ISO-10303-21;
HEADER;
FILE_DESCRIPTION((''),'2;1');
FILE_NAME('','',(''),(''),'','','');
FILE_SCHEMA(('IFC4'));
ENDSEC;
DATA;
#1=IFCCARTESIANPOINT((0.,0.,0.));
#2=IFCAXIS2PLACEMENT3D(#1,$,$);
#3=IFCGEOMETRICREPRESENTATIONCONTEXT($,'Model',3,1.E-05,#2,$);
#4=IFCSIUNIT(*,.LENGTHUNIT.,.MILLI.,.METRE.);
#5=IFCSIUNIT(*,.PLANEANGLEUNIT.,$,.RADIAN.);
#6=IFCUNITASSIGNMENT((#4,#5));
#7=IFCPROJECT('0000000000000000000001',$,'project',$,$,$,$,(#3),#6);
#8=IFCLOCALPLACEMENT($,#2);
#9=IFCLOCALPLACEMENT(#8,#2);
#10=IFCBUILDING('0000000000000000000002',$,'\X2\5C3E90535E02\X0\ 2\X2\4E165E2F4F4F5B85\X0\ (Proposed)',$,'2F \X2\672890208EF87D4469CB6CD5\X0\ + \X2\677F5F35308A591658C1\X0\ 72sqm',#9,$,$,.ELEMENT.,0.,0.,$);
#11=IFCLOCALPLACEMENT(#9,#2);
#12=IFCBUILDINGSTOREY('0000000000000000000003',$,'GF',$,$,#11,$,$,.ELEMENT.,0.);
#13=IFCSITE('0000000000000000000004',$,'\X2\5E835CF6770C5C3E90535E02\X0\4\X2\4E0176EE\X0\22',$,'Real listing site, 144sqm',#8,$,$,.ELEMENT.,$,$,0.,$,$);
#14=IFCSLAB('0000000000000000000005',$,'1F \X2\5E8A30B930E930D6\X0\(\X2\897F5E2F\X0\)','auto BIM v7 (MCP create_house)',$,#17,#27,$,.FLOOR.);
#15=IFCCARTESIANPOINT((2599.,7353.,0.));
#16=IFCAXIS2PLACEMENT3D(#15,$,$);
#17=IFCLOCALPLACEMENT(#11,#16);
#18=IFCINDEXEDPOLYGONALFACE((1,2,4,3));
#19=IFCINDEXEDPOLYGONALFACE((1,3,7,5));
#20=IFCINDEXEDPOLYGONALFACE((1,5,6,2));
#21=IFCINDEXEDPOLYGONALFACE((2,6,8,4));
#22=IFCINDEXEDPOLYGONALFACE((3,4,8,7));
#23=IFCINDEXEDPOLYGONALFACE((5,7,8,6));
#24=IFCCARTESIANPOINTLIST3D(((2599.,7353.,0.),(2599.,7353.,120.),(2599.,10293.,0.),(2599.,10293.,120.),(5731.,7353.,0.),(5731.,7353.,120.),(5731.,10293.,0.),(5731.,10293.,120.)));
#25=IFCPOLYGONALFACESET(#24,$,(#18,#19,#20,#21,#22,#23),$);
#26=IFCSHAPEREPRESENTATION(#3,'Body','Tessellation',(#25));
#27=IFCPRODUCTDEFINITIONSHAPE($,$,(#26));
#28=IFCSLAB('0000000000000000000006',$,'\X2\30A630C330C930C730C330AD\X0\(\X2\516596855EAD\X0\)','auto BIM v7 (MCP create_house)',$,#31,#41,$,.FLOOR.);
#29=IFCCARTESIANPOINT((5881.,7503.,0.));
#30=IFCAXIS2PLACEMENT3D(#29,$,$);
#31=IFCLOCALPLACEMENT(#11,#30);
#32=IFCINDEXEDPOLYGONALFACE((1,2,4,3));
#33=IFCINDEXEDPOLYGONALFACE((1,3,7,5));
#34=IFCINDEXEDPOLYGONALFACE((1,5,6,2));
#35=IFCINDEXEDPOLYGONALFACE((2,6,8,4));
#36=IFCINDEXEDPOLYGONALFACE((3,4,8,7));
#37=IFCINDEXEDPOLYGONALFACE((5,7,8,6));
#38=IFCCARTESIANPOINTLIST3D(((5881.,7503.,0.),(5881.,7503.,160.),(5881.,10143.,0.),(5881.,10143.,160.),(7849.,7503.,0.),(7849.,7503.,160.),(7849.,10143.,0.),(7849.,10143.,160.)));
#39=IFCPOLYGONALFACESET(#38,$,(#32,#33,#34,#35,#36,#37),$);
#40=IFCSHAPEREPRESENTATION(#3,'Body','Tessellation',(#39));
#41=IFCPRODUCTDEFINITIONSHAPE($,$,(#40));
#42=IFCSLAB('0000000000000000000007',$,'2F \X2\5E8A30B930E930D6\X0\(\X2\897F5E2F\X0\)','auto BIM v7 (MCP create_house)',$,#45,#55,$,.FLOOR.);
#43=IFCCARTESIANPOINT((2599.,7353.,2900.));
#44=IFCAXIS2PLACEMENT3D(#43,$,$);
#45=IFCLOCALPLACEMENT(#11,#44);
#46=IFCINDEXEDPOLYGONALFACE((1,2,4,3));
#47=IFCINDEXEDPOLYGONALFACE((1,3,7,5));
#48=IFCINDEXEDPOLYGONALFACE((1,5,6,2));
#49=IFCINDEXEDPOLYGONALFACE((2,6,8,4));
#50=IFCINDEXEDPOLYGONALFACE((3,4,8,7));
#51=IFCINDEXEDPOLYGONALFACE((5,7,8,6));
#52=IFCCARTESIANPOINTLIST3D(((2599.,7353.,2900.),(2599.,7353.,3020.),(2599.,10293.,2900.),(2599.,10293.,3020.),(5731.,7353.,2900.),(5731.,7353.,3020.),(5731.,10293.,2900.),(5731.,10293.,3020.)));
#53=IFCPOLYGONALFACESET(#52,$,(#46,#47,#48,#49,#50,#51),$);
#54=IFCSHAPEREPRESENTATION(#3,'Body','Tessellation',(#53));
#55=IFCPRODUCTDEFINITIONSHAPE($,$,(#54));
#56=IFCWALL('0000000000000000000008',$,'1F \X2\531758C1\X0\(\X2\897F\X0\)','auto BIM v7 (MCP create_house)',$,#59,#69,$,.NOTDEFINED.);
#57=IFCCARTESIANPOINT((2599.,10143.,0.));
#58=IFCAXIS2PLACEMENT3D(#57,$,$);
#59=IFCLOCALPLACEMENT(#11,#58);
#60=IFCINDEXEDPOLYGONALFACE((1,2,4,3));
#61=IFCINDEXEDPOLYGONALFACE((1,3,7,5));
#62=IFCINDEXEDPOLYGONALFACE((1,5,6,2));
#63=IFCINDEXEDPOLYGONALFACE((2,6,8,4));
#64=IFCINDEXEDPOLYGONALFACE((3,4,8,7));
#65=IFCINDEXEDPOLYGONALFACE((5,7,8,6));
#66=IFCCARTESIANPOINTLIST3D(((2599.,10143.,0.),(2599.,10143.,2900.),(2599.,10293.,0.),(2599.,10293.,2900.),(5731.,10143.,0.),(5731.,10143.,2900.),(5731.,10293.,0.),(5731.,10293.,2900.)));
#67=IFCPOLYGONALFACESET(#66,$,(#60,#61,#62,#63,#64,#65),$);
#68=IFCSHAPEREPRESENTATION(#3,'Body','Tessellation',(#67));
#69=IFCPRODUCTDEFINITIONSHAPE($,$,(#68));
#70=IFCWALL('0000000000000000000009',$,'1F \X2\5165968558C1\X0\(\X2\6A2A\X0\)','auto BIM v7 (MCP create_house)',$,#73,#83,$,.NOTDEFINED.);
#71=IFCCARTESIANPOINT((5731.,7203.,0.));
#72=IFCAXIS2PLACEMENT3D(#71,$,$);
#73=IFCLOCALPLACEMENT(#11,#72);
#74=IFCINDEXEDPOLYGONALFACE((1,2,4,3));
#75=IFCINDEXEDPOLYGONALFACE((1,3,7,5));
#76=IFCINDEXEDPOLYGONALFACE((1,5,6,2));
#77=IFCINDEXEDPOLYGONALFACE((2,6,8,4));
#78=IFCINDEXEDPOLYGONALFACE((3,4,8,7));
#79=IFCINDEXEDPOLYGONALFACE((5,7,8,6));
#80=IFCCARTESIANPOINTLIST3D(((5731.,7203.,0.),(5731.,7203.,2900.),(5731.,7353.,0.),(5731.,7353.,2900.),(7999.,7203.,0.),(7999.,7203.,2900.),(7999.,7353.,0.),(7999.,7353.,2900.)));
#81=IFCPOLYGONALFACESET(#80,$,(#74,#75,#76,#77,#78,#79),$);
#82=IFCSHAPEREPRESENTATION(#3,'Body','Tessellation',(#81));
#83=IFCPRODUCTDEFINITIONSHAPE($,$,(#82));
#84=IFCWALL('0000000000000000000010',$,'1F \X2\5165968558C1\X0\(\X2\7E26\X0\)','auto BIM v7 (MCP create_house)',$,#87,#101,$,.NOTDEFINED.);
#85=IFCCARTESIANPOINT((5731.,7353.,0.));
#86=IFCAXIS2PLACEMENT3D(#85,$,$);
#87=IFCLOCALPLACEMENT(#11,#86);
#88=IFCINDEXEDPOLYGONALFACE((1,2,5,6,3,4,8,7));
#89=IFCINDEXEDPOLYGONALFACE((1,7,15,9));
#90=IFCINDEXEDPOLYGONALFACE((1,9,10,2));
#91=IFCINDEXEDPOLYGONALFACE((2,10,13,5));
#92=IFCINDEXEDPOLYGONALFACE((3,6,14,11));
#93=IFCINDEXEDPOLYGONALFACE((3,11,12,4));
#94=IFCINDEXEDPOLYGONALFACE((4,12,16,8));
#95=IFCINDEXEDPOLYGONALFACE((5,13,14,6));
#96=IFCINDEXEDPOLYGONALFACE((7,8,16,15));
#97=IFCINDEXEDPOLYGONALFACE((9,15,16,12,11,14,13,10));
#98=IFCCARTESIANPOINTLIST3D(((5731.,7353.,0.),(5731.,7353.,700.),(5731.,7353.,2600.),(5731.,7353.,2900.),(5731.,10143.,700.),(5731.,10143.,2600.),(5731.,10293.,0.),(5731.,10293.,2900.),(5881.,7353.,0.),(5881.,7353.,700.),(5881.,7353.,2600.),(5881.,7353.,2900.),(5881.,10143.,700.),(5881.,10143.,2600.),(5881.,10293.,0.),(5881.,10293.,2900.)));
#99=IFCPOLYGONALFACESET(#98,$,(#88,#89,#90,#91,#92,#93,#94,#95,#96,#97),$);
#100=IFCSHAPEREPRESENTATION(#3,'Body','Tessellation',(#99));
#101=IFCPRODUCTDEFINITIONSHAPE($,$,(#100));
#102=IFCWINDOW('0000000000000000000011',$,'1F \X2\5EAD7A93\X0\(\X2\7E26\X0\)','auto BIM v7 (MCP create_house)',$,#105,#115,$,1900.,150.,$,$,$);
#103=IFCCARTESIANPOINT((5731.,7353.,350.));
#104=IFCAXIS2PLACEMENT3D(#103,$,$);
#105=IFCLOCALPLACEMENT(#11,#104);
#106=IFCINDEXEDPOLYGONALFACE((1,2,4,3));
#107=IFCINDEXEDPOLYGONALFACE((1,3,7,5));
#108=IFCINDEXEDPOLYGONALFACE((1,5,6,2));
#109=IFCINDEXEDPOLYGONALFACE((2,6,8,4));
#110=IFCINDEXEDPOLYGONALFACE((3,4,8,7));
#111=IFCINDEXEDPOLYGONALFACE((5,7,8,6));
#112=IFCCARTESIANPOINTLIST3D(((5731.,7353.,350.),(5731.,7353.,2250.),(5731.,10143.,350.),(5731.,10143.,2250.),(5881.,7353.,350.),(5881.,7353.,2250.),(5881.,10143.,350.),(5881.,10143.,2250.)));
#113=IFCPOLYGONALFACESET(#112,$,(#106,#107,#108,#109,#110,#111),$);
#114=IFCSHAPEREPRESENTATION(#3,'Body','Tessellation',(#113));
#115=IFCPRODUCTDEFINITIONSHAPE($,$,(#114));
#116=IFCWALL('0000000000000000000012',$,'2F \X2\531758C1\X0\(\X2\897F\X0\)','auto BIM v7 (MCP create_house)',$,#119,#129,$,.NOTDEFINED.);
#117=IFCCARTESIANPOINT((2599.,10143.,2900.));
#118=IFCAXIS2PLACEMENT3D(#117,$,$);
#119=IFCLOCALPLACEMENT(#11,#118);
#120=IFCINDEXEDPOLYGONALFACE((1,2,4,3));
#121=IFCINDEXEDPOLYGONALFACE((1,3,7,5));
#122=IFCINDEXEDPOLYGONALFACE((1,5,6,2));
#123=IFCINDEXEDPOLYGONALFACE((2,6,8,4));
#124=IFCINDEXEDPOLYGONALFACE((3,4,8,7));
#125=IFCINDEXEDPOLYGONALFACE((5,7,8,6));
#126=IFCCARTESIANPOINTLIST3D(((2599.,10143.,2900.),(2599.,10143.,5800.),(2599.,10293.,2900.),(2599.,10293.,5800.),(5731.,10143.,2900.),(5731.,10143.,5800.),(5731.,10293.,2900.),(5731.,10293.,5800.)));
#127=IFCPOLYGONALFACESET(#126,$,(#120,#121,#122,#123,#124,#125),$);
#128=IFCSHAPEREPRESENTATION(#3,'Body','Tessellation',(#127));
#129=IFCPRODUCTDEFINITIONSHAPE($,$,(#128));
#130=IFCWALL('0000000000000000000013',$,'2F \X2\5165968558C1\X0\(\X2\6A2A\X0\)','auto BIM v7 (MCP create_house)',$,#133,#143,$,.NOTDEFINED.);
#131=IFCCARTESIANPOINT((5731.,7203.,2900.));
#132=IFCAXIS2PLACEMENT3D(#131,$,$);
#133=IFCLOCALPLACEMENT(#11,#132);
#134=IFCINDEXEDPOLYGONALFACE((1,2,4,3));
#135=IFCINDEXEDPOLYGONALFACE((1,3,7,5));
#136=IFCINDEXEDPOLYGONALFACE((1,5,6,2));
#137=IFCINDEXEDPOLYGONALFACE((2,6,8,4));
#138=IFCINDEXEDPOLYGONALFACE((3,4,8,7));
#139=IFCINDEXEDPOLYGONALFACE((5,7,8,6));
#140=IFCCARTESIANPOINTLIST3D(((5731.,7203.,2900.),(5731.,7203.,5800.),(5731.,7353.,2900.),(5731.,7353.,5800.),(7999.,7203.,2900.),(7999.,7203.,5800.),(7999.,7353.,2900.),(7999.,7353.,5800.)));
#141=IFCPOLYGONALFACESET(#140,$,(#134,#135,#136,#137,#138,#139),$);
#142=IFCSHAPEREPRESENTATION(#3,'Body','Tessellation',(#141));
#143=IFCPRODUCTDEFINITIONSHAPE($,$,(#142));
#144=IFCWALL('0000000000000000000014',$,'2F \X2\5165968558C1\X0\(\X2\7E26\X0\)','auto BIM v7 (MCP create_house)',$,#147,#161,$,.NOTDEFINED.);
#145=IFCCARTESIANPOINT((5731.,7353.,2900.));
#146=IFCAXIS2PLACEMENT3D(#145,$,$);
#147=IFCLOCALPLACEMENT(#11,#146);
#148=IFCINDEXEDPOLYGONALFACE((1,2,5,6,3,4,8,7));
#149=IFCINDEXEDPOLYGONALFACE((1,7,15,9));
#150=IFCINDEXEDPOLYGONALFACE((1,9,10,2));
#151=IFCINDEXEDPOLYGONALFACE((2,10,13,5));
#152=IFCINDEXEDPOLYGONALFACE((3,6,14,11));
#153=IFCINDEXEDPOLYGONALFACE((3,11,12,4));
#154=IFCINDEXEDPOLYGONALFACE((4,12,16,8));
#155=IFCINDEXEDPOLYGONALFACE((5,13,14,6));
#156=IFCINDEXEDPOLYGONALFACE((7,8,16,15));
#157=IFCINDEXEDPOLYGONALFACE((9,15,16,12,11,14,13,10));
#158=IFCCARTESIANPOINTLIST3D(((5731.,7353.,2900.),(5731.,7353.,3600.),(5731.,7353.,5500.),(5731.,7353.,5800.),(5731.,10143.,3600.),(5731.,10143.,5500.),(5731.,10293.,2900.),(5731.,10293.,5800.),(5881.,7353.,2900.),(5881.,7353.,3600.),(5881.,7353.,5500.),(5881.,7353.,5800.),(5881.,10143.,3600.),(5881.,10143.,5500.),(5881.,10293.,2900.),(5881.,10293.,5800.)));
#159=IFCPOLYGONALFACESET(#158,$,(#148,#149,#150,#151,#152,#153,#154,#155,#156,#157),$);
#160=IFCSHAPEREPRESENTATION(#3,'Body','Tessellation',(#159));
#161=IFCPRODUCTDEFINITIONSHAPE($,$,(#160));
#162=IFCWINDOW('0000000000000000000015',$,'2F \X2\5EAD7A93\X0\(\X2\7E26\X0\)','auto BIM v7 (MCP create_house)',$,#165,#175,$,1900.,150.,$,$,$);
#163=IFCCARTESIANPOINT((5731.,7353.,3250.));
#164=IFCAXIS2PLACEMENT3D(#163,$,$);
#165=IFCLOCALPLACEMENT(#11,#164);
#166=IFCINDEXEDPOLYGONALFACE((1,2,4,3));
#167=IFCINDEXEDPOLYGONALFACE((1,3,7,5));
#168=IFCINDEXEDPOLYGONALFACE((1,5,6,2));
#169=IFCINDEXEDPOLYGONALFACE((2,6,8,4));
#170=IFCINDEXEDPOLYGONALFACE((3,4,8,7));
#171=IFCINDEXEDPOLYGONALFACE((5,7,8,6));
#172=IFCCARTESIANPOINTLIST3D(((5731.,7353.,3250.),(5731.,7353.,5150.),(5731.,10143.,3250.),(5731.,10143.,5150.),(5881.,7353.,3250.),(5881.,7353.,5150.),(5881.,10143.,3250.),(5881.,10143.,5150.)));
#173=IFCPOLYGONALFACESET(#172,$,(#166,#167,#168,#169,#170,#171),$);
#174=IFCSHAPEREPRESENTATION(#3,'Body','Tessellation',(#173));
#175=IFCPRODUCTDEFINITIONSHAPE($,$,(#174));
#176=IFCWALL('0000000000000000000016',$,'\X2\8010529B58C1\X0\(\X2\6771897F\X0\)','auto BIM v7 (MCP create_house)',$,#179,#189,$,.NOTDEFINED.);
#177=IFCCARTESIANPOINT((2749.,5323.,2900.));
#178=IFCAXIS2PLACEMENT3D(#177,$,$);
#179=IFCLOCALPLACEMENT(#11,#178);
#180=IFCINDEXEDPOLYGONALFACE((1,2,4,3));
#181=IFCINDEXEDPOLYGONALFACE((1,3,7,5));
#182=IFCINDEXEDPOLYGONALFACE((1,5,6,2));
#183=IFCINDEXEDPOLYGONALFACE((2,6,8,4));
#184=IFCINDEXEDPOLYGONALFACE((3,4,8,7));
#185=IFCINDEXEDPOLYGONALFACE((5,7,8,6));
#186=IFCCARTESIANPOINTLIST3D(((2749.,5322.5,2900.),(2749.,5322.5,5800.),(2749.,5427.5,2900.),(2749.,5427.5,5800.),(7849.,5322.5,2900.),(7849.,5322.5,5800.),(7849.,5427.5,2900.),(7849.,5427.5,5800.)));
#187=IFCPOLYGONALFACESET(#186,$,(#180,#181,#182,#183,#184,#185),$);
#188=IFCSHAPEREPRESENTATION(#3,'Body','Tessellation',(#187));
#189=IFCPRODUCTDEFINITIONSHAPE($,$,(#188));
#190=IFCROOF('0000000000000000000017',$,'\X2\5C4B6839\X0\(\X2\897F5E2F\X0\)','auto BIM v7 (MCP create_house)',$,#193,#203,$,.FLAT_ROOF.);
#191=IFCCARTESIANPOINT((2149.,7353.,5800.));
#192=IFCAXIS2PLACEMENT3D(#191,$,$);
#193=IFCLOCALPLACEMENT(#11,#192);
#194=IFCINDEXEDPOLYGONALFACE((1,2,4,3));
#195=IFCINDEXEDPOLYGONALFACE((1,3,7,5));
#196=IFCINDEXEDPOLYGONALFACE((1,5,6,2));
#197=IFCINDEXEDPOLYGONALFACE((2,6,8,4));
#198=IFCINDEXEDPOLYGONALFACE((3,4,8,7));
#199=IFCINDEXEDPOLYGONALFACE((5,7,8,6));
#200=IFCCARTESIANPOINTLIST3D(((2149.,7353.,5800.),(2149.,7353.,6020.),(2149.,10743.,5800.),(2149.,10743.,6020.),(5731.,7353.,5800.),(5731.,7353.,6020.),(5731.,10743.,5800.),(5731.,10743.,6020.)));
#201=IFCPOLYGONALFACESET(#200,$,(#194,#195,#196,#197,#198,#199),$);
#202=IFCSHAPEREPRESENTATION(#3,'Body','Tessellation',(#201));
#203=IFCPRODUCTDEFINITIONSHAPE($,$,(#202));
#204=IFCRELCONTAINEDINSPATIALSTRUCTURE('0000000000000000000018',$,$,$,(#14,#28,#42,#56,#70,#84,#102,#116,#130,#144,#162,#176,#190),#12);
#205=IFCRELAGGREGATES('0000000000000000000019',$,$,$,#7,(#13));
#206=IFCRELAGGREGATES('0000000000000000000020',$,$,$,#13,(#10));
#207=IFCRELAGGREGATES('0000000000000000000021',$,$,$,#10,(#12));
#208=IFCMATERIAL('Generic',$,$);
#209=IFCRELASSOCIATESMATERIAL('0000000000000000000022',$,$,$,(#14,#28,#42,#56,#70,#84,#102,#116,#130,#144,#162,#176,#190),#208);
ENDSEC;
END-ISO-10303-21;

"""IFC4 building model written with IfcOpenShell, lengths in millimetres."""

from ifc_helpers import new_model, si_unit, frame, frame_2d, origin, place, context, project, spatial, rectangle, extrude, material, element, fill, save


model = new_model("IFC4")

# Units and contexts
model_context = context("Model", 3, precision=1e-05, world=origin())
ifc_project = project(units=[si_unit("LENGTHUNIT", "METRE", prefix="MILLI"), si_unit("PLANEANGLEUNIT", "RADIAN")], contexts=[model_context])

# Site, building, storey
site_placement = place(None, origin())
site = spatial("IfcSite", under=ifc_project, at=site_placement, Name="広島県尾道市4丁目22", ObjectType="Real listing site, 144sqm", CompositionType="ELEMENT", RefElevation=0.0)
building_placement = place(site_placement, origin())
building = spatial("IfcBuilding", under=site, at=building_placement, Name="尾道市 2世帯住宅 (Proposed)", ObjectType="2F 木造軸組構法 + 板張り外壁 72sqm", CompositionType="ELEMENT", ElevationOfRefHeight=0.0, ElevationOfTerrain=0.0)
storey_placement = place(building_placement, origin())
storey = spatial("IfcBuildingStorey", under=building, at=storey_placement, Name="GF", CompositionType="ELEMENT", Elevation=0.0)

# Slabs
ifc_material = material(Name="Generic")
slab_1_placement = place(storey_placement, frame((2599.0, 7353.0, 0.0)))
element("IfcSlab", 1, at=slab_1_placement, inside=storey, material=ifc_material, Name="1F 床スラブ(西帯)", Description="auto BIM v7 (MCP create_house)", PredefinedType="FLOOR", context=model_context, shape_type="SweptSolid", body=[
    extrude(rectangle(XDim=3132.0, YDim=2940.0, at=frame_2d((1566.0, 1470.0))), frame((2599.0, 7353.0, 0.0)), (0.0, 0.0, 1.0), 120.0),
])
slab_2_placement = place(storey_placement, frame((5881.0, 7503.0, 0.0)))
element("IfcSlab", 2, at=slab_2_placement, inside=storey, material=ifc_material, Name="ウッドデッキ(入隅庭)", Description="auto BIM v7 (MCP create_house)", PredefinedType="FLOOR", context=model_context, shape_type="SweptSolid", body=[
    extrude(rectangle(XDim=1968.0, YDim=2640.0, at=frame_2d((984.0, 1320.0))), frame((5881.0, 7503.0, 0.0)), (0.0, 0.0, 1.0), 160.0),
])
slab_3_placement = place(storey_placement, frame((2599.0, 7353.0, 2900.0)))
element("IfcSlab", 3, at=slab_3_placement, inside=storey, material=ifc_material, Name="2F 床スラブ(西帯)", Description="auto BIM v7 (MCP create_house)", PredefinedType="FLOOR", context=model_context, shape_type="SweptSolid", body=[
    extrude(rectangle(XDim=3132.0, YDim=2940.0, at=frame_2d((1566.0, 1470.0))), frame((2599.0, 7353.0, 2900.0)), (0.0, 0.0, 1.0), 120.0),
])

# Walls
wall_1_placement = place(storey_placement, frame((2599.0, 10143.0, 0.0)))
element("IfcWall", 4, at=wall_1_placement, inside=storey, material=ifc_material, Name="1F 北壁(西)", Description="auto BIM v7 (MCP create_house)", PredefinedType="NOTDEFINED", context=model_context, shape_type="SweptSolid", body=[
    extrude(rectangle(XDim=3132.0, YDim=150.0, at=frame_2d((1566.0, 75.0))), frame((2599.0, 10143.0, 0.0)), (0.0, 0.0, 1.0), 2900.0),
])
wall_2_placement = place(storey_placement, frame((5731.0, 7203.0, 0.0)))
element("IfcWall", 5, at=wall_2_placement, inside=storey, material=ifc_material, Name="1F 入隅壁(横)", Description="auto BIM v7 (MCP create_house)", PredefinedType="NOTDEFINED", context=model_context, shape_type="SweptSolid", body=[
    extrude(rectangle(XDim=2268.0, YDim=150.0, at=frame_2d((1134.0, 75.0))), frame((5731.0, 7203.0, 0.0)), (0.0, 0.0, 1.0), 2900.0),
])

# Wall, opening, window
wall_3_placement = place(storey_placement, frame((5731.0, 7353.0, 0.0)))
wall_3 = element("IfcWall", 6, at=wall_3_placement, inside=storey, material=ifc_material, Name="1F 入隅壁(縦)", Description="auto BIM v7 (MCP create_house)", PredefinedType="NOTDEFINED", context=model_context, shape_type="SweptSolid", body=[
    extrude(rectangle(XDim=150.0, YDim=2940.0, at=frame_2d((75.0, 1470.0))), frame((5731.0, 7353.0, 0.0)), (0.0, 0.0, 1.0), 2900.0),
])
opening_1_placement = place(storey_placement, frame((5731.0, 7353.0, 350.0)))
opening_1 = element("IfcOpeningElement", 7, at=opening_1_placement, cuts=wall_3, PredefinedType="NOTDEFINED", context=model_context, shape_type="SweptSolid", body=[
    extrude(rectangle(XDim=150.0, YDim=2790.0, at=frame_2d((75.0, 1395.0))), frame((5731.0, 7353.0, 350.0)), (0.0, 0.0, 1.0), 1900.0),
])
window_1_placement = place(storey_placement, frame((5731.0, 7353.0, 350.0)))
window_1 = element("IfcWindow", 8, at=window_1_placement, inside=storey, material=ifc_material, Name="1F 庭窓(縦)", Description="auto BIM v7 (MCP create_house)", OverallHeight=1900.0, OverallWidth=150.0, context=model_context, shape_type="SweptSolid", body=[
    extrude(rectangle(XDim=150.0, YDim=2790.0, at=frame_2d((75.0, 1395.0))), frame((5731.0, 7353.0, 350.0)), (0.0, 0.0, 1.0), 1900.0),
])
fill(opening_1, window_1)

# Walls
wall_4_placement = place(storey_placement, frame((2599.0, 10143.0, 2900.0)))
element("IfcWall", 9, at=wall_4_placement, inside=storey, material=ifc_material, Name="2F 北壁(西)", Description="auto BIM v7 (MCP create_house)", PredefinedType="NOTDEFINED", context=model_context, shape_type="SweptSolid", body=[
    extrude(rectangle(XDim=3132.0, YDim=150.0, at=frame_2d((1566.0, 75.0))), frame((2599.0, 10143.0, 2900.0)), (0.0, 0.0, 1.0), 2900.0),
])
wall_5_placement = place(storey_placement, frame((5731.0, 7203.0, 2900.0)))
element("IfcWall", 10, at=wall_5_placement, inside=storey, material=ifc_material, Name="2F 入隅壁(横)", Description="auto BIM v7 (MCP create_house)", PredefinedType="NOTDEFINED", context=model_context, shape_type="SweptSolid", body=[
    extrude(rectangle(XDim=2268.0, YDim=150.0, at=frame_2d((1134.0, 75.0))), frame((5731.0, 7203.0, 2900.0)), (0.0, 0.0, 1.0), 2900.0),
])

# Wall, opening, window
wall_6_placement = place(storey_placement, frame((5731.0, 7353.0, 2900.0)))
wall_6 = element("IfcWall", 11, at=wall_6_placement, inside=storey, material=ifc_material, Name="2F 入隅壁(縦)", Description="auto BIM v7 (MCP create_house)", PredefinedType="NOTDEFINED", context=model_context, shape_type="SweptSolid", body=[
    extrude(rectangle(XDim=150.0, YDim=2940.0, at=frame_2d((75.0, 1470.0))), frame((5731.0, 7353.0, 2900.0)), (0.0, 0.0, 1.0), 2900.0),
])
opening_2_placement = place(storey_placement, frame((5731.0, 7353.0, 3250.0)))
opening_2 = element("IfcOpeningElement", 12, at=opening_2_placement, cuts=wall_6, PredefinedType="NOTDEFINED", context=model_context, shape_type="SweptSolid", body=[
    extrude(rectangle(XDim=150.0, YDim=2790.0, at=frame_2d((75.0, 1395.0))), frame((5731.0, 7353.0, 3250.0)), (0.0, 0.0, 1.0), 1900.0),
])
window_2_placement = place(storey_placement, frame((5731.0, 7353.0, 3250.0)))
window_2 = element("IfcWindow", 13, at=window_2_placement, inside=storey, material=ifc_material, Name="2F 庭窓(縦)", Description="auto BIM v7 (MCP create_house)", OverallHeight=1900.0, OverallWidth=150.0, context=model_context, shape_type="SweptSolid", body=[
    extrude(rectangle(XDim=150.0, YDim=2790.0, at=frame_2d((75.0, 1395.0))), frame((5731.0, 7353.0, 3250.0)), (0.0, 0.0, 1.0), 1900.0),
])
fill(opening_2, window_2)

# Wall
wall_7_placement = place(storey_placement, frame((2749.0, 5323.0, 2900.0)))
element("IfcWall", 14, at=wall_7_placement, inside=storey, material=ifc_material, Name="耐力壁(東西)", Description="auto BIM v7 (MCP create_house)", PredefinedType="NOTDEFINED", context=model_context, shape_type="SweptSolid", body=[
    extrude(rectangle(XDim=5100.0, YDim=105.0, at=frame_2d((2550.0, 52.0))), frame((2749.0, 5323.0, 2900.0)), (0.0, 0.0, 1.0), 2900.0),
])

# Roof
for number, where, name in (
    (15, (2149.0, 7353.0, 5800.0), "屋根(西帯)"),
):
    element("IfcRoof", number, at=place(storey_placement, frame(where)), inside=storey, material=ifc_material, Name=name, Description="auto BIM v7 (MCP create_house)", PredefinedType="FLAT_ROOF", context=model_context, shape_type="SweptSolid", body=[
        extrude(rectangle(XDim=3582.0, YDim=3390.0, at=frame_2d((1791.0, 1695.0))), frame((2149.0, 7353.0, 5800.0)), (0.0, 0.0, 1.0), 220.0),
    ])

save(model, "model.ifc")
